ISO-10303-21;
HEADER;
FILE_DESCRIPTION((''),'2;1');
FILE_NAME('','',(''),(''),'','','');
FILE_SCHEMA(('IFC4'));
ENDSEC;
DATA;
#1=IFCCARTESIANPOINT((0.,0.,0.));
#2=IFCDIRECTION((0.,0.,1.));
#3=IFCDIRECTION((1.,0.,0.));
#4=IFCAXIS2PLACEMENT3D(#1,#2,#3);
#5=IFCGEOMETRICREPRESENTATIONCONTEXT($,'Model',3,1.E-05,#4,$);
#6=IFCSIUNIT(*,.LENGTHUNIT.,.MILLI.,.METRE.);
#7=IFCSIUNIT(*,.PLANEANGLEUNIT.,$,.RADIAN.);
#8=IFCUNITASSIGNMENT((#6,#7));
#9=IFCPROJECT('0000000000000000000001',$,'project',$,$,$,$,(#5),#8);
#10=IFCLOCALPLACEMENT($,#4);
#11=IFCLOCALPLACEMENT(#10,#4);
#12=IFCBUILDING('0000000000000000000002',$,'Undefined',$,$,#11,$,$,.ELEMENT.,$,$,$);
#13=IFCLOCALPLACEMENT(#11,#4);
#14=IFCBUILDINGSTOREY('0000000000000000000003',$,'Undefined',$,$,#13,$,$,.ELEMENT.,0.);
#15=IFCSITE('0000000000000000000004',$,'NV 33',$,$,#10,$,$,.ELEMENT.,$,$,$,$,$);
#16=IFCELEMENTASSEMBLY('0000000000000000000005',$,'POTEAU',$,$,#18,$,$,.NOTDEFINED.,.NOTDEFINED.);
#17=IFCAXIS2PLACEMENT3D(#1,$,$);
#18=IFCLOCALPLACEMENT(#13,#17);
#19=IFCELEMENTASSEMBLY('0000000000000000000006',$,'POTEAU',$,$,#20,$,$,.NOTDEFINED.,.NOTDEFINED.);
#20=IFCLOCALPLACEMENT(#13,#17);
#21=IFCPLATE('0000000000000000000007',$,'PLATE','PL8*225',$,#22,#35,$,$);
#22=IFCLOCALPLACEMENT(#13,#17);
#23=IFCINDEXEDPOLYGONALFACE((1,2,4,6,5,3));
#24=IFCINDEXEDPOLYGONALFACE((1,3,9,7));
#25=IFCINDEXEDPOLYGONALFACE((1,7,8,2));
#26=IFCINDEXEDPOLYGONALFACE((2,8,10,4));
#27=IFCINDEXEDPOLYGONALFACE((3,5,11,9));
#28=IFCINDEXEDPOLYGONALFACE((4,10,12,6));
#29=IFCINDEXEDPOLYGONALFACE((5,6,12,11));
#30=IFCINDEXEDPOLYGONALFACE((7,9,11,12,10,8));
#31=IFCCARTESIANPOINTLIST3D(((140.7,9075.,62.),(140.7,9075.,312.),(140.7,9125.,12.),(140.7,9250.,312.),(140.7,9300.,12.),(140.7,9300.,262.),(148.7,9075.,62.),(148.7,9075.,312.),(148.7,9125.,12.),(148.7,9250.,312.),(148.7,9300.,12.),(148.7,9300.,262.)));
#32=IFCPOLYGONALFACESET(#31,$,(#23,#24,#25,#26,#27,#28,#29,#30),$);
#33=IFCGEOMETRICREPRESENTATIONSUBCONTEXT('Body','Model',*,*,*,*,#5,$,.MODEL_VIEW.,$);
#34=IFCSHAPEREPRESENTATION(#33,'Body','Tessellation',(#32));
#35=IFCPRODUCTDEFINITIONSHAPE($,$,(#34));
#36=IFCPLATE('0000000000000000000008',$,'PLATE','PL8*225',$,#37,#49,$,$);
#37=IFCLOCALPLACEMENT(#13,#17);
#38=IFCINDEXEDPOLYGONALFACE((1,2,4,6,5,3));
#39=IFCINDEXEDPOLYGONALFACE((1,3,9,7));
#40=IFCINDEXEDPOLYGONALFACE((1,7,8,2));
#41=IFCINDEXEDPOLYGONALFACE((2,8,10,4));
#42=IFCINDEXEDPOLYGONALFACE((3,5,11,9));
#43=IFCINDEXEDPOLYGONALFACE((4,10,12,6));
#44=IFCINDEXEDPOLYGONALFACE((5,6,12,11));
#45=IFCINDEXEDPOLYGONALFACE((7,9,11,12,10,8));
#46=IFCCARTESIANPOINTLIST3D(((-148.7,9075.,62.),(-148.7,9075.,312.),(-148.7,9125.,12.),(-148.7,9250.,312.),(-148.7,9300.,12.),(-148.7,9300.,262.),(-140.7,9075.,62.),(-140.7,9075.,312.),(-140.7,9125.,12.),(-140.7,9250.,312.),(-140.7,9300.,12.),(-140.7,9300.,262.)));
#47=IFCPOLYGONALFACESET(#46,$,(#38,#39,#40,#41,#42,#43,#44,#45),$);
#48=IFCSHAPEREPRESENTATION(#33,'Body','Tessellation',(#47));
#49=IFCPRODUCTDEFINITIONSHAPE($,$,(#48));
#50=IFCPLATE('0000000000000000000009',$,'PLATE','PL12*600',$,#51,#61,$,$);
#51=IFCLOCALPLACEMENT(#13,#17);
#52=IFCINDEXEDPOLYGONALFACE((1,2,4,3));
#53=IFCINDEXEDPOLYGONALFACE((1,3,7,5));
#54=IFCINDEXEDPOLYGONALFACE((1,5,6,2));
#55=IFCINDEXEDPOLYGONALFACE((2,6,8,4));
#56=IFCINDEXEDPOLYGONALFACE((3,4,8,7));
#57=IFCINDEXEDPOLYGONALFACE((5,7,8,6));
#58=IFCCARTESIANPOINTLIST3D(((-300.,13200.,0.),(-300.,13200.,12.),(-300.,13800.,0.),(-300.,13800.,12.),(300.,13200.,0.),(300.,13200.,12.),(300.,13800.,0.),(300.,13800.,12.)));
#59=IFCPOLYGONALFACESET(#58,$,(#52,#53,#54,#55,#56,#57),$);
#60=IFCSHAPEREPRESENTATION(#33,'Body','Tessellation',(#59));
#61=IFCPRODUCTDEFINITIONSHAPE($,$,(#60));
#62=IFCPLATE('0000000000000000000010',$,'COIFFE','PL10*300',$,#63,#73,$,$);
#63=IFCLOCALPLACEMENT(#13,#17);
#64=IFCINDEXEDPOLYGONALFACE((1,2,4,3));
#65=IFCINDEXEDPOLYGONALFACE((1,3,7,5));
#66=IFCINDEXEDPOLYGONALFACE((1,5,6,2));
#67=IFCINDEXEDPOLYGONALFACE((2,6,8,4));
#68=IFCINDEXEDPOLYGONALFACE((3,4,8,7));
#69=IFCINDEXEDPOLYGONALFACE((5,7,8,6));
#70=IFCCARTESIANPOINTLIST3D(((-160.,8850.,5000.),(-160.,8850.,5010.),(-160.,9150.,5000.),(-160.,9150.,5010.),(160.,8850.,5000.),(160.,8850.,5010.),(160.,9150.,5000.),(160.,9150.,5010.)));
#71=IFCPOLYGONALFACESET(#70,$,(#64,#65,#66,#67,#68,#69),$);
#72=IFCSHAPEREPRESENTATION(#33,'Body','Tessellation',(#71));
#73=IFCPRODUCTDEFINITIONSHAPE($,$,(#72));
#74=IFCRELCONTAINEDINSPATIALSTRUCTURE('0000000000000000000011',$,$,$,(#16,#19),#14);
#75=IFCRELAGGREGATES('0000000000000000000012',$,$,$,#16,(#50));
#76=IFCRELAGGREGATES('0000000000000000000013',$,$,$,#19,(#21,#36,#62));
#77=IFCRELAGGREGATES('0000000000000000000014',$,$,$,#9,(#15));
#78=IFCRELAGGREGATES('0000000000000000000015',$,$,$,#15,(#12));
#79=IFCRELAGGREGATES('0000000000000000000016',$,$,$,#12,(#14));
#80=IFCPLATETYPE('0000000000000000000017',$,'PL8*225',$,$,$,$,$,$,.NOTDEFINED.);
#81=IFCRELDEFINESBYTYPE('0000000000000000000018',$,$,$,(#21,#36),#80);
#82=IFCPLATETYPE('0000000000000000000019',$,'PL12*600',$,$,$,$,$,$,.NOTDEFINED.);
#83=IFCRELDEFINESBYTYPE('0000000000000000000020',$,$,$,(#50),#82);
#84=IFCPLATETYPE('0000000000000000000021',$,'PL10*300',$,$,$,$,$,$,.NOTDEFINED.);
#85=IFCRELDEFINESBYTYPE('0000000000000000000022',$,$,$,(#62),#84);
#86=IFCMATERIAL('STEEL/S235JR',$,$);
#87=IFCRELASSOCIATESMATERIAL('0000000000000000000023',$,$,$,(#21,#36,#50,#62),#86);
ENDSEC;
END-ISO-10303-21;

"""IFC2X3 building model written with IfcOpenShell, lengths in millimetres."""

from ifc_helpers import new_model, si_unit, frame, origin_with_axes, place, context, subcontext, project, spatial, polyline, outline, extrude, material, type_object, element, aggregate, save


model = new_model("IFC2X3")

# Units and contexts
model_context = context("Model", 3, precision=1e-05, world=origin_with_axes())
body_context = subcontext(model_context, "Body", "Model", "MODEL_VIEW")
ifc_project = project(units=[si_unit("LENGTHUNIT", "METRE", prefix="MILLI"), si_unit("PLANEANGLEUNIT", "RADIAN")], contexts=[model_context])

# Site, building, storey
site_placement = place(None, origin_with_axes())
site = spatial("IfcSite", under=ifc_project, at=site_placement, Name="NV 33", CompositionType="ELEMENT")
building_placement = place(site_placement, origin_with_axes())
building = spatial("IfcBuilding", under=site, at=building_placement, Name="Undefined", CompositionType="ELEMENT")
storey_placement = place(building_placement, origin_with_axes())
storey = spatial("IfcBuildingStorey", under=building, at=storey_placement, Name="Undefined", CompositionType="ELEMENT", Elevation=0.0)

# Shared definitions
ifc_material_1 = material(Name="STEEL/S235JR")

# Element assemblies
assembly_1_placement = place(storey_placement, origin_with_axes())
assembly_1 = element("IfcElementAssembly", 1, at=assembly_1_placement, inside=storey, Name="POTEAU", AssemblyPlace="NOTDEFINED", PredefinedType="NOTDEFINED")
assembly_2_placement = place(storey_placement, origin_with_axes())
assembly_2 = element("IfcElementAssembly", 2, at=assembly_2_placement, inside=storey, Name="POTEAU", AssemblyPlace="NOTDEFINED", PredefinedType="NOTDEFINED")

# Plates
plate_type_1 = type_object("IfcPlateType", Name="PL8*225", PredefinedType="NOTDEFINED")
plate_1_placement = place(assembly_2_placement, frame((144.7, 9075.0, 12.0), z_axis=(1.0, 0.0, 0.0), x_axis=(0.0, 1.0, 0.0)))
plate_1 = element("IfcPlate", 3, at=plate_1_placement, type_object=plate_type_1, material=ifc_material_1, Name="PLATE", Description="PL8*225", context=body_context, shape_type="SweptSolid", body=[
    extrude(outline(polyline([(0.0, 50.0), (50.0, 0.0), (225.0, 0.0), (225.0, 250.0), (175.0, 300.0), (0.0, 300.0), (0.0, 50.0)])), frame((0.0, 0.0, -4.0), z_axis=(0.0, 0.0, 1.0), x_axis=(1.0, 0.0, 0.0)), (0.0, 0.0, 1.0), 8.0),
])
plate_2_placement = place(assembly_2_placement, frame((-144.7, 9075.0, 12.0), z_axis=(1.0, 0.0, 0.0), x_axis=(0.0, 1.0, 0.0)))
plate_2 = element("IfcPlate", 4, at=plate_2_placement, type_object=plate_type_1, material=ifc_material_1, Name="PLATE", Description="PL8*225", context=body_context, shape_type="SweptSolid", body=[
    extrude(outline(polyline([(0.0, 50.0), (50.0, 0.0), (225.0, 0.0), (225.0, 250.0), (175.0, 300.0), (0.0, 300.0), (0.0, 50.0)])), frame((0.0, 0.0, -4.0), z_axis=(0.0, 0.0, 1.0), x_axis=(1.0, 0.0, 0.0)), (0.0, 0.0, 1.0), 8.0),
])
plate_type_2 = type_object("IfcPlateType", Name="PL12*600", PredefinedType="NOTDEFINED")
plate_3_placement = place(assembly_1_placement, frame((-300.0, 13200.0, 6.0), z_axis=(0.0, 0.0, 1.0), x_axis=(1.0, 0.0, 0.0)))
plate_3 = element("IfcPlate", 5, at=plate_3_placement, type_object=plate_type_2, material=ifc_material_1, Name="PLATE", Description="PL12*600", context=body_context, shape_type="SweptSolid", body=[
    extrude(outline(polyline([(0.0, 0.0), (600.0, 0.0), (600.0, 600.0), (0.0, 600.0), (0.0, 0.0)])), frame((0.0, 0.0, -6.0), z_axis=(0.0, 0.0, 1.0), x_axis=(1.0, 0.0, 0.0)), (0.0, 0.0, 1.0), 12.0),
])
aggregate(assembly_1, [plate_3])
plate_type_3 = type_object("IfcPlateType", Name="PL10*300", PredefinedType="NOTDEFINED")
plate_4_placement = place(assembly_2_placement, frame((-160.0, 9150.0, 5005.0), z_axis=(0.0, 0.0, 1.0), x_axis=(0.0, -1.0, 0.0)))
plate_4 = element("IfcPlate", 6, at=plate_4_placement, type_object=plate_type_3, material=ifc_material_1, Name="COIFFE", Description="PL10*300", context=body_context, shape_type="SweptSolid", body=[
    extrude(outline(polyline([(0.0, 0.0), (300.0, 0.0), (300.0, 320.0), (0.0, 320.0), (0.0, 0.0)])), frame((0.0, 0.0, -5.0), z_axis=(0.0, 0.0, 1.0), x_axis=(1.0, 0.0, 0.0)), (0.0, 0.0, 1.0), 10.0),
])
aggregate(assembly_2, [plate_1, plate_2, plate_4])

save(model, "model.ifc")
